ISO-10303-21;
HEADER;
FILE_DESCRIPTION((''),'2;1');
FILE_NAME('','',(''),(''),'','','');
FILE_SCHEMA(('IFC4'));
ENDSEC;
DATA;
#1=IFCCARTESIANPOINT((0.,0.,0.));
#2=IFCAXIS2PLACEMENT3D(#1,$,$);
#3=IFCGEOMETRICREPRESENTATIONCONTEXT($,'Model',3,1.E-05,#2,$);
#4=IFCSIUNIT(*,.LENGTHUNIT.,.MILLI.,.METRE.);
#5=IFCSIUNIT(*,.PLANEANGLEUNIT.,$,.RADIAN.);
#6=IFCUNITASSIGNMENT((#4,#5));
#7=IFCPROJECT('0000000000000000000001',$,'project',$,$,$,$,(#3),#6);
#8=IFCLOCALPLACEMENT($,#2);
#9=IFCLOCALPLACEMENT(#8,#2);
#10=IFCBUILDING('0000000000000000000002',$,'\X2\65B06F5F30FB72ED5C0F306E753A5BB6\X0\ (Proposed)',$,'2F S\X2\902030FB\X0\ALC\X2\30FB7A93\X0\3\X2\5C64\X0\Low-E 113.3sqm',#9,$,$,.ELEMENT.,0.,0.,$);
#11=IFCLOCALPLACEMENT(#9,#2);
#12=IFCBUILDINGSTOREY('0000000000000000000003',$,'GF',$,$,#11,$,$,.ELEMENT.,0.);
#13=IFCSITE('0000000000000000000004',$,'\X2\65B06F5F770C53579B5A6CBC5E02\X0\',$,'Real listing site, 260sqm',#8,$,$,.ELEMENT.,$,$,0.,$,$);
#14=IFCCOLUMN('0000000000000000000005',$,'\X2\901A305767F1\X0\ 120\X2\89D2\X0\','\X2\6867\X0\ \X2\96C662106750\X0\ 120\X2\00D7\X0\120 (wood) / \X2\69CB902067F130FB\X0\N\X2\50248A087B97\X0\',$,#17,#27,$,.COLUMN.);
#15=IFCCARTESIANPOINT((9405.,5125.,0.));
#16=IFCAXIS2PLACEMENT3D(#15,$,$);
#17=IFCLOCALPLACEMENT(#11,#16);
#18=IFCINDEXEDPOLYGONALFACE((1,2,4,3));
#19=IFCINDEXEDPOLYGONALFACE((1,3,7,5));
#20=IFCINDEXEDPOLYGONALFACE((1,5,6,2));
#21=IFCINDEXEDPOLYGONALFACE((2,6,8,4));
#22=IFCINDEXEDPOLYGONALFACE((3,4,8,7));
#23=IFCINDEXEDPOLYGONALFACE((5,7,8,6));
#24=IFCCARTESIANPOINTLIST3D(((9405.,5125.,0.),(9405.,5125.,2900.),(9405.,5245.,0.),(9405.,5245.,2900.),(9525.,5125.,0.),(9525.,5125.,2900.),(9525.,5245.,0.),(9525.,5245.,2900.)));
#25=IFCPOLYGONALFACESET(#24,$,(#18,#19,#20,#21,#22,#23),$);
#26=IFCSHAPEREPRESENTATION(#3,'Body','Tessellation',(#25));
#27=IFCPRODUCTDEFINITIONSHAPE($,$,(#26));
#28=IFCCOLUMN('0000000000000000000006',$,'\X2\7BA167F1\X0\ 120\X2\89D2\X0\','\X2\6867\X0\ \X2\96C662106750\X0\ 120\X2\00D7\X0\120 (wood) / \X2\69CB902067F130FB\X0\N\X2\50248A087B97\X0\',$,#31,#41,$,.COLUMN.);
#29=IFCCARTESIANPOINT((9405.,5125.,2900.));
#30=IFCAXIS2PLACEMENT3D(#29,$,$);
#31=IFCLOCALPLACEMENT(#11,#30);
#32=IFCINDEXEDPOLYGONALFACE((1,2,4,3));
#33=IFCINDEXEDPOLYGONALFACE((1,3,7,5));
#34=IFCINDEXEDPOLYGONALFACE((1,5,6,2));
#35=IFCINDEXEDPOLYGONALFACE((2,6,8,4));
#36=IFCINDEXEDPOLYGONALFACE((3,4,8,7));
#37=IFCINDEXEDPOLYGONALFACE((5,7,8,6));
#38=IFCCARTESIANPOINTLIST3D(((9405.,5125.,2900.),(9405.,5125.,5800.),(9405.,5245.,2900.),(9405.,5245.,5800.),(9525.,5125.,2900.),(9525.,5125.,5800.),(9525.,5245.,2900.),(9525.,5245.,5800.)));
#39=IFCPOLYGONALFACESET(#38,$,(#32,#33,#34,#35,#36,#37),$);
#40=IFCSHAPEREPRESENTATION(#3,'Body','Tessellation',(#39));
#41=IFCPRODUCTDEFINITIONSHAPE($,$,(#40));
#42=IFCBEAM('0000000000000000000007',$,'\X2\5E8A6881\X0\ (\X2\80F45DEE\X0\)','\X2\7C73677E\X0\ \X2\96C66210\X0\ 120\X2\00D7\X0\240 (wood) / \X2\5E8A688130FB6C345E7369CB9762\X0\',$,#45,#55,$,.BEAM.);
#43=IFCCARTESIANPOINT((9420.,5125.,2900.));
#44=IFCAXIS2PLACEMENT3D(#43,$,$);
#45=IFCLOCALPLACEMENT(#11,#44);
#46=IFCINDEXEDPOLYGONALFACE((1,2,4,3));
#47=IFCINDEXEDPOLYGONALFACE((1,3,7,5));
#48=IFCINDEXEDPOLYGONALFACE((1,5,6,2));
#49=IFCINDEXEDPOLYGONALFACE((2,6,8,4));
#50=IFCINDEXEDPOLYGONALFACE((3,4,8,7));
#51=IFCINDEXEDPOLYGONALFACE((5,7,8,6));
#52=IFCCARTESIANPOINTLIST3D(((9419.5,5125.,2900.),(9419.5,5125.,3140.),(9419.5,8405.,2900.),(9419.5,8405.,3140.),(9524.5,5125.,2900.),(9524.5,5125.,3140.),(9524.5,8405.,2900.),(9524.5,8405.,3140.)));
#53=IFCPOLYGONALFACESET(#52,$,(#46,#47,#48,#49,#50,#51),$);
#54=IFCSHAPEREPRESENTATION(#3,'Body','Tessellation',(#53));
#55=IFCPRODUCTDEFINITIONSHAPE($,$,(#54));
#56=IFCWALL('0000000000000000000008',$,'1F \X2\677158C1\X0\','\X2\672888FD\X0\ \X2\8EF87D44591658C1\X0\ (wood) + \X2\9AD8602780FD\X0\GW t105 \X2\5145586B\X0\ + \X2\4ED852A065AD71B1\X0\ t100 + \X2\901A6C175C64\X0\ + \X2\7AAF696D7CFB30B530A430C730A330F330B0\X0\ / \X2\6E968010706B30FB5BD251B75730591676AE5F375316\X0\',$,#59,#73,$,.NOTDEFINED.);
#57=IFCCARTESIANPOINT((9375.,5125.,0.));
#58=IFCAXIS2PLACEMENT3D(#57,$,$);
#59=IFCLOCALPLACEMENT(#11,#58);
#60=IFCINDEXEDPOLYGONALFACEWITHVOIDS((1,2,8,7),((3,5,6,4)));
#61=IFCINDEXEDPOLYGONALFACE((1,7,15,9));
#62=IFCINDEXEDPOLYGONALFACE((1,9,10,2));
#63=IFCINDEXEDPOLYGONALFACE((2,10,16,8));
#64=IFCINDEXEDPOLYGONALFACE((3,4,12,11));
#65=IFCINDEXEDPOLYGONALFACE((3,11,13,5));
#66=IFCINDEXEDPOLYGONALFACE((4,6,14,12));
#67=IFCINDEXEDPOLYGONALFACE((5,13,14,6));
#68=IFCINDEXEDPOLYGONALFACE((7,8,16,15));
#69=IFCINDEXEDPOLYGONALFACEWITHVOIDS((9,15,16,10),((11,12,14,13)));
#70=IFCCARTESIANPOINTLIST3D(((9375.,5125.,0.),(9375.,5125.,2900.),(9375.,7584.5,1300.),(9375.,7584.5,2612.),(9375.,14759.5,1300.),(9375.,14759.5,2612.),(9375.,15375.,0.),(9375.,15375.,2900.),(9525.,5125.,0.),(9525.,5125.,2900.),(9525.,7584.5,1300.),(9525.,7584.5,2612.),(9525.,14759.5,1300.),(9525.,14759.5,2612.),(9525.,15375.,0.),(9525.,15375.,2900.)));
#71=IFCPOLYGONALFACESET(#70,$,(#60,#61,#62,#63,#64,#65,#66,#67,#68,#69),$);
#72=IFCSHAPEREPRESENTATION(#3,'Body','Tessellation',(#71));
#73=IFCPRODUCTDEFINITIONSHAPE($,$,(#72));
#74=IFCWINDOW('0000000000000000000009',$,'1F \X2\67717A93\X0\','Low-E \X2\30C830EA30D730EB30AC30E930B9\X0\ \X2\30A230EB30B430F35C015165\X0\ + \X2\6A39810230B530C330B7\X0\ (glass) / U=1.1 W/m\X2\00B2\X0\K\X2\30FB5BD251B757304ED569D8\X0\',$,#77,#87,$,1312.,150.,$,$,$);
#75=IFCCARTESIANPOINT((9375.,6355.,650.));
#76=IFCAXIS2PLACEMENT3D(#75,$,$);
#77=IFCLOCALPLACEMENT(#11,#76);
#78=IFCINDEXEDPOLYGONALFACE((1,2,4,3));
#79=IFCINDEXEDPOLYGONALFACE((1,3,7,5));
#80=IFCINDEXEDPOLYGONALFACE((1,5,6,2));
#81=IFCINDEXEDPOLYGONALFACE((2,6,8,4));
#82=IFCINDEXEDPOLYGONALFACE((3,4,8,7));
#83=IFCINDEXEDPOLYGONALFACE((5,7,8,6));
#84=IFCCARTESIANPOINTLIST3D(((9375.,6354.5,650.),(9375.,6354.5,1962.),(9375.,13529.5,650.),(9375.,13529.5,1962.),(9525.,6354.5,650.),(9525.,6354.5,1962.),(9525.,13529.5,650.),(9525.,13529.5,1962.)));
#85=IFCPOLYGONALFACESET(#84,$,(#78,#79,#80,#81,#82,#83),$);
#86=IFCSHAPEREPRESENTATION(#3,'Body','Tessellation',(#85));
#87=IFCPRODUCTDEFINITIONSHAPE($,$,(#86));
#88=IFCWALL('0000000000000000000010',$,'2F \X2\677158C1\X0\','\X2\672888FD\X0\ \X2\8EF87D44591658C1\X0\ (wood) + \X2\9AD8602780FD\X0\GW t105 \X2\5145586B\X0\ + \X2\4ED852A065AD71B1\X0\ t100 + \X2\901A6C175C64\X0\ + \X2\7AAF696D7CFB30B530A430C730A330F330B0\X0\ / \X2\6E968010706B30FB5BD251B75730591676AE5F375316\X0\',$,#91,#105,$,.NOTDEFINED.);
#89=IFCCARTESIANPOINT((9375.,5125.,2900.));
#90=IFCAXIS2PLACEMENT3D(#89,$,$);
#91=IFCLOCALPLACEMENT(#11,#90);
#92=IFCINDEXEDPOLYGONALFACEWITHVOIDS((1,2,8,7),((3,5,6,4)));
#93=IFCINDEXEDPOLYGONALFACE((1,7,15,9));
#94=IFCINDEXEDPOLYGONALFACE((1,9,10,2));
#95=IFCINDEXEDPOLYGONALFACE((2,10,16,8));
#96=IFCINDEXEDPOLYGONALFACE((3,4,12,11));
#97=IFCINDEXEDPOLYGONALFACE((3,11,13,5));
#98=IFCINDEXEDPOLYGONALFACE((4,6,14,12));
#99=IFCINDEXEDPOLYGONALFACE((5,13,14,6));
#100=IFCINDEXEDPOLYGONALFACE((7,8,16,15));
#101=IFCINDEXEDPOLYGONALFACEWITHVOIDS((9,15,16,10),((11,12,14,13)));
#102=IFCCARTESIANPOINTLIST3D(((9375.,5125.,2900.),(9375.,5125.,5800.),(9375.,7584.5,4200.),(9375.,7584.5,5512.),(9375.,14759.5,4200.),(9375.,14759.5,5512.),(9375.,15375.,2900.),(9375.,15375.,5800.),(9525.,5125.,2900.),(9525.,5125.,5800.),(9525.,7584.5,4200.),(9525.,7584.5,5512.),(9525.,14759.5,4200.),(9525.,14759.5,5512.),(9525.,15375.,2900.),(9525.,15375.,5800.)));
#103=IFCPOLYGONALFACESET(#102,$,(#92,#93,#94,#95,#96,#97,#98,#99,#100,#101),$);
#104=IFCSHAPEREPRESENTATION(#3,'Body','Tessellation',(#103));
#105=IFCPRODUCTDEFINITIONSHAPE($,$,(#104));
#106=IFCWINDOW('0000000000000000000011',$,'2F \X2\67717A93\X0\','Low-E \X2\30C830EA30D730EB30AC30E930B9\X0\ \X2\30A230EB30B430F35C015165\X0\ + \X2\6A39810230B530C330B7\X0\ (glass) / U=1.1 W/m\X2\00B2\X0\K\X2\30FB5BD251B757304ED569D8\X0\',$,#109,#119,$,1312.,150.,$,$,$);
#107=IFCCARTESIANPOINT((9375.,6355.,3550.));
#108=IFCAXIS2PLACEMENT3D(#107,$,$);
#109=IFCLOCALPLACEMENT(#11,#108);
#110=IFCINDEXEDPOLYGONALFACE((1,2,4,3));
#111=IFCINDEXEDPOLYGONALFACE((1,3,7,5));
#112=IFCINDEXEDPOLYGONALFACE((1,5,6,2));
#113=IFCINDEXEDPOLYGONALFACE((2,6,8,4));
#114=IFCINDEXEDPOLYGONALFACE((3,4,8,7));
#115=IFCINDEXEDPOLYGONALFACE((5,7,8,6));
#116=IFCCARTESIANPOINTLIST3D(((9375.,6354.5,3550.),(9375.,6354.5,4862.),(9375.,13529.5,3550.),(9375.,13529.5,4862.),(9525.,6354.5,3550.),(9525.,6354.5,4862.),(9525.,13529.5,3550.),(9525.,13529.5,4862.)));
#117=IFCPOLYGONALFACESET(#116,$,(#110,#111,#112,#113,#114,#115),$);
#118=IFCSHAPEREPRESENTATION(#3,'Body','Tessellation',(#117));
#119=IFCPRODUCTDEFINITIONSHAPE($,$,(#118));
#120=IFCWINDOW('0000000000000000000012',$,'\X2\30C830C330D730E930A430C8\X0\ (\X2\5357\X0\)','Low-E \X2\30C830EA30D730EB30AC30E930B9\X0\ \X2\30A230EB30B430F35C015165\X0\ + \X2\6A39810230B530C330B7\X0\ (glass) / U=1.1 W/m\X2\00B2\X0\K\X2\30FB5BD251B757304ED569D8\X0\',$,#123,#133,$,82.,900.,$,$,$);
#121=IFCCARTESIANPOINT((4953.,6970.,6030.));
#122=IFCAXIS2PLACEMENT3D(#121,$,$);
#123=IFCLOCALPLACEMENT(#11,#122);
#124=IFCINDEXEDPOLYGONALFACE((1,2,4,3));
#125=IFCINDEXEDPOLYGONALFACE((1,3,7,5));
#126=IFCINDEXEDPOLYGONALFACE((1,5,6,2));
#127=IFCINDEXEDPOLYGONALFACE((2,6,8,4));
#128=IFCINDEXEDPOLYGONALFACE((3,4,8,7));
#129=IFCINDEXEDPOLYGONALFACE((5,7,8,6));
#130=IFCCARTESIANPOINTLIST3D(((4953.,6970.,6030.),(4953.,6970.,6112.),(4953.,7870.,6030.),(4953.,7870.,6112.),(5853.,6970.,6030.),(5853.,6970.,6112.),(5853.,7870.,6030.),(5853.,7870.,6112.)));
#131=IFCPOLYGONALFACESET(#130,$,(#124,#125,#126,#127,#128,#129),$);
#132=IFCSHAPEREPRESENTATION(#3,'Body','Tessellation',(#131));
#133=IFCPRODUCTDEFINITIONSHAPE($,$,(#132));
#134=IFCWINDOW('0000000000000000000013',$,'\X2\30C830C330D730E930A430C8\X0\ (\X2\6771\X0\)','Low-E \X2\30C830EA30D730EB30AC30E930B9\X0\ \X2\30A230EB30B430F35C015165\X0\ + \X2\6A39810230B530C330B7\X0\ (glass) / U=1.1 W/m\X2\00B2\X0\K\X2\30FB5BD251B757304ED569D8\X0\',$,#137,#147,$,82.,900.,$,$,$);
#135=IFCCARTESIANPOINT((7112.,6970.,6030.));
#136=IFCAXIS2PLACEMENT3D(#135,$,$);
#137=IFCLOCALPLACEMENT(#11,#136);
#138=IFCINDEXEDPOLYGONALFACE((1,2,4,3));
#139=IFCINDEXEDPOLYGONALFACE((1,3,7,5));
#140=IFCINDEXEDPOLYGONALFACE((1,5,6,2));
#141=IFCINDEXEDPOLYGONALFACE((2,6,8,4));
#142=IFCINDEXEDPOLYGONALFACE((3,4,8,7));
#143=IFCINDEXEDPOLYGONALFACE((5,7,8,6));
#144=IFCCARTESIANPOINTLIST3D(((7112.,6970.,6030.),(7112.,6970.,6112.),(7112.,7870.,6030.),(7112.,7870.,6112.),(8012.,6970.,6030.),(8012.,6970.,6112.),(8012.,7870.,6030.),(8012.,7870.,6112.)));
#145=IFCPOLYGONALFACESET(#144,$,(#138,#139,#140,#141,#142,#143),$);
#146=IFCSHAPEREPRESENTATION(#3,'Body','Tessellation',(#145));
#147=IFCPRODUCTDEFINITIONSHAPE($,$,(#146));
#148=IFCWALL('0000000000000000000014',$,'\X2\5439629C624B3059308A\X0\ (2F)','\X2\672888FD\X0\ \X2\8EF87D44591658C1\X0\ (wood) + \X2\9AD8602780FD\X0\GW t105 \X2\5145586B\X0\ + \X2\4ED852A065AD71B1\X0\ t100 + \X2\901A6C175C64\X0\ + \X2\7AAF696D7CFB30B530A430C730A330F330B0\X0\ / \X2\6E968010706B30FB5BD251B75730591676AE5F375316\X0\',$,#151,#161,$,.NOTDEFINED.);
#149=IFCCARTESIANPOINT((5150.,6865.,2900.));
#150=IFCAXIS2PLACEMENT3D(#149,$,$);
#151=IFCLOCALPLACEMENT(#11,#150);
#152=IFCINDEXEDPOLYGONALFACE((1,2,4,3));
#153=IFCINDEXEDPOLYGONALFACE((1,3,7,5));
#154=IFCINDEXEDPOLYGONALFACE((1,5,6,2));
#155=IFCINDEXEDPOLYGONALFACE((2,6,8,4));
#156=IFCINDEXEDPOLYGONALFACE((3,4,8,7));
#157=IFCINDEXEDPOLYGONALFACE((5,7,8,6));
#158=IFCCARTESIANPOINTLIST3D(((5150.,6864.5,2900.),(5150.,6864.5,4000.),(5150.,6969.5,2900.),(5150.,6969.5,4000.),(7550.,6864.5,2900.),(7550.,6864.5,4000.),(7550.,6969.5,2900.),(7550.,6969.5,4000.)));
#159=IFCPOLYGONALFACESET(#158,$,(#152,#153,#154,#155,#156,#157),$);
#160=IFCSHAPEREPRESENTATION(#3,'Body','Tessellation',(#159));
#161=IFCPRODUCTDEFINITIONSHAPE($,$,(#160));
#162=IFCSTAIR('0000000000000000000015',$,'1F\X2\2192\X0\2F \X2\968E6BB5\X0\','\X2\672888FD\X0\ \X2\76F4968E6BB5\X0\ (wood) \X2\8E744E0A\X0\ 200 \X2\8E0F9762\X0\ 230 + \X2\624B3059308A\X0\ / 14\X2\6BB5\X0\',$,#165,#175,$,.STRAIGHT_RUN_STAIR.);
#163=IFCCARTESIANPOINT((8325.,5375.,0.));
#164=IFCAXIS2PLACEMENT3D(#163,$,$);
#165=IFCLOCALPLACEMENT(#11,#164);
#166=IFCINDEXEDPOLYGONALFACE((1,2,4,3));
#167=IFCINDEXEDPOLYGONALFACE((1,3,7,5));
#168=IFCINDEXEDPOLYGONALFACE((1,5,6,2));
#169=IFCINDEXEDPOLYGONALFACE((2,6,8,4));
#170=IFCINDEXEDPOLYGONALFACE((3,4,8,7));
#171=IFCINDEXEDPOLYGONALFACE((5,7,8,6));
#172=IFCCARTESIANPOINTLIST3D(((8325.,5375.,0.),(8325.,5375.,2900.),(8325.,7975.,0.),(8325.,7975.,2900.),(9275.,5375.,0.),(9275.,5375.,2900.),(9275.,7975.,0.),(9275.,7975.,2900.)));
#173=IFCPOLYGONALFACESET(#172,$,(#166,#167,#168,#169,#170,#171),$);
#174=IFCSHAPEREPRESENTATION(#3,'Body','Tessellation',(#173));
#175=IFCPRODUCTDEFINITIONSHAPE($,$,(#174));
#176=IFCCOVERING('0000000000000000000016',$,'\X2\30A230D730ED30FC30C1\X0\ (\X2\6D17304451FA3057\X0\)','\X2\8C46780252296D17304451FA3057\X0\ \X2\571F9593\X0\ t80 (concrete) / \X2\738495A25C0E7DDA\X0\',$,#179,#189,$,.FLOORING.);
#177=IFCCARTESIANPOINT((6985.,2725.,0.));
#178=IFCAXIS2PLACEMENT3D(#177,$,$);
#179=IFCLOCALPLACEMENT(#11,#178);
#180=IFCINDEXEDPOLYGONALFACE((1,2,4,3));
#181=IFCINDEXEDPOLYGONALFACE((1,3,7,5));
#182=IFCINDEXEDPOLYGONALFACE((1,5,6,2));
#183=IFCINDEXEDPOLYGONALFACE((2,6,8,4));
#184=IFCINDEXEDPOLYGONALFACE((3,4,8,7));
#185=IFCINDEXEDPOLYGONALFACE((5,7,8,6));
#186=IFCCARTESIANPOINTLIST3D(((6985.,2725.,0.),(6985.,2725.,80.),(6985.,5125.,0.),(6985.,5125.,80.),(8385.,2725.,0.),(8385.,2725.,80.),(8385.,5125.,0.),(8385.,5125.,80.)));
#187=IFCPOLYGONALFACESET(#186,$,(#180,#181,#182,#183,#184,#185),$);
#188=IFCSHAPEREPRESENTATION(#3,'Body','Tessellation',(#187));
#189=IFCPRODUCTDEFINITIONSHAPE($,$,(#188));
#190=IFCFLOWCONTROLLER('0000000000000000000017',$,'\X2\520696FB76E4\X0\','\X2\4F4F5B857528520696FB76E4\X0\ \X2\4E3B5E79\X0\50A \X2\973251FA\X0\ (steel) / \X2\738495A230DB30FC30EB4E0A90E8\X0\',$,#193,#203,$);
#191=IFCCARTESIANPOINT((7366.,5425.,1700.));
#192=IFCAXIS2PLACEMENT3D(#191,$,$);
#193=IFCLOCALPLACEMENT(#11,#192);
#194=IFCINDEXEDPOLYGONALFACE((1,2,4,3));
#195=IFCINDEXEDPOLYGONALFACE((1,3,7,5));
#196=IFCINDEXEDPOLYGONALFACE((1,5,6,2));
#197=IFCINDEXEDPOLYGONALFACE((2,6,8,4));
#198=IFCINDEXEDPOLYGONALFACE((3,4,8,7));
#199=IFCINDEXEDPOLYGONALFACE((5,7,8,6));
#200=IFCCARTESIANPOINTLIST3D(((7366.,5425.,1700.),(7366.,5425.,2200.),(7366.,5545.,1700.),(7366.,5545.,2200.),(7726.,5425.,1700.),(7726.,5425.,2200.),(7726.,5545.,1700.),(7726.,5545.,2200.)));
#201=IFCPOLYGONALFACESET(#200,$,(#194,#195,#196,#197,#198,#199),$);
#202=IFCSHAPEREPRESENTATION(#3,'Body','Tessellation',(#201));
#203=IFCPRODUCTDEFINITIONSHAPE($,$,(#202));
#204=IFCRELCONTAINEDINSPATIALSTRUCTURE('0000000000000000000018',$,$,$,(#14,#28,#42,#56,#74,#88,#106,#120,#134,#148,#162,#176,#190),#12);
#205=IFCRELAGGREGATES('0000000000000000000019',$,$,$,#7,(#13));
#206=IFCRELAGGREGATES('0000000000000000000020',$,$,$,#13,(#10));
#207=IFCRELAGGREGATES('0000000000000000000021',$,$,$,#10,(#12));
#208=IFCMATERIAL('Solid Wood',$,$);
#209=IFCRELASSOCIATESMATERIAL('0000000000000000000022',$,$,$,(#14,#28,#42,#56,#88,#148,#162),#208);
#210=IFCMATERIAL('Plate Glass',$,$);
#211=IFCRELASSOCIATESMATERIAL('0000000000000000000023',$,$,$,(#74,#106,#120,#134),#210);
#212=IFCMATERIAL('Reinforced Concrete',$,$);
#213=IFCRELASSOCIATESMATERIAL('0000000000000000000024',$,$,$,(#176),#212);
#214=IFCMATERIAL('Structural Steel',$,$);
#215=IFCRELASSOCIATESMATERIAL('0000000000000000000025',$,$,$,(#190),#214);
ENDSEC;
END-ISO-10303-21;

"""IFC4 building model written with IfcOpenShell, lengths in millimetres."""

from ifc_helpers import new_model, si_unit, frame, frame_2d, origin, place, context, project, spatial, rectangle, extrude, material, element, fill, save


model = new_model("IFC4")

# Units and contexts
model_context = context("Model", 3, precision=1e-05, world=origin())
ifc_project = project(units=[si_unit("LENGTHUNIT", "METRE", prefix="MILLI"), si_unit("PLANEANGLEUNIT", "RADIAN")], contexts=[model_context])

# Site, building, storey
site_placement = place(None, origin())
site = spatial("IfcSite", under=ifc_project, at=site_placement, Name="新潟県南魚沼市", ObjectType="Real listing site, 260sqm", CompositionType="ELEMENT", RefElevation=0.0)
building_placement = place(site_placement, origin())
building = spatial("IfcBuilding", under=site, at=building_placement, Name="新潟・狭小の町家 (Proposed)", ObjectType="2F S造・ALC・窓3層Low-E 113.3sqm", CompositionType="ELEMENT", ElevationOfRefHeight=0.0, ElevationOfTerrain=0.0)
storey_placement = place(building_placement, origin())
storey = spatial("IfcBuildingStorey", under=building, at=storey_placement, Name="GF", CompositionType="ELEMENT", Elevation=0.0)

# Columns
ifc_material_1 = material(Name="Solid Wood")
column_1_placement = place(storey_placement, frame((9405.0, 5125.0, 0.0)))
element("IfcColumn", 1, at=column_1_placement, inside=storey, material=ifc_material_1, Name="通し柱 120角", Description="桧 集成材 120×120 (wood) / 構造柱・N値計算", PredefinedType="COLUMN", context=model_context, shape_type="SweptSolid", body=[
    extrude(rectangle(XDim=120.0, YDim=120.0, at=frame_2d((60.0, 60.0))), frame((9405.0, 5125.0, 0.0)), (0.0, 0.0, 1.0), 2900.0),
])
column_2_placement = place(storey_placement, frame((9405.0, 5125.0, 2900.0)))
element("IfcColumn", 2, at=column_2_placement, inside=storey, material=ifc_material_1, Name="管柱 120角", Description="桧 集成材 120×120 (wood) / 構造柱・N値計算", PredefinedType="COLUMN", context=model_context, shape_type="SweptSolid", body=[
    extrude(rectangle(XDim=120.0, YDim=120.0, at=frame_2d((60.0, 60.0))), frame((9405.0, 5125.0, 2900.0)), (0.0, 0.0, 1.0), 2900.0),
])

# Beam
beam_1_placement = place(storey_placement, frame((9420.0, 5125.0, 2900.0)))
element("IfcBeam", 3, at=beam_1_placement, inside=storey, material=ifc_material_1, Name="床梁 (胴差)", Description="米松 集成 120×240 (wood) / 床梁・水平構面", PredefinedType="BEAM", context=model_context, shape_type="SweptSolid", body=[
    extrude(rectangle(XDim=105.0, YDim=3280.0, at=frame_2d((52.0, 1640.0))), frame((9420.0, 5125.0, 2900.0)), (0.0, 0.0, 1.0), 240.0),
])

# Wall, opening, window
wall_1_placement = place(storey_placement, frame((9375.0, 5125.0, 0.0)))
wall_1 = element("IfcWall", 4, at=wall_1_placement, inside=storey, material=ifc_material_1, Name="1F 東壁", Description="木製 軸組外壁 (wood) + 高性能GW t105 充填 + 付加断熱 t100 + 通気層 + 窯業系サイディング / 準耐火・寒冷地外皮強化", PredefinedType="NOTDEFINED", context=model_context, shape_type="SweptSolid", body=[
    extrude(rectangle(XDim=150.0, YDim=10250.0, at=frame_2d((75.0, 5125.0))), frame((9375.0, 5125.0, 0.0)), (0.0, 0.0, 1.0), 2900.0),
])
opening_1_placement = place(storey_placement, frame((9375.0, 6355.0, 650.0)))
opening_1 = element("IfcOpeningElement", 5, at=opening_1_placement, cuts=wall_1, PredefinedType="NOTDEFINED", context=model_context, shape_type="SweptSolid", body=[
    extrude(rectangle(XDim=150.0, YDim=7175.0, at=frame_2d((75.0, 3587.0))), frame((9375.0, 6355.0, 650.0)), (0.0, 0.0, 1.0), 1312.0),
])
ifc_material_2 = material(Name="Plate Glass")
window_1_placement = place(storey_placement, frame((9375.0, 6355.0, 650.0)))
window_1 = element("IfcWindow", 6, at=window_1_placement, inside=storey, material=ifc_material_2, Name="1F 東窓", Description="Low-E トリプルガラス アルゴン封入 + 樹脂サッシ (glass) / U=1.1 W/m²K・寒冷地仕様", OverallHeight=1312.0, OverallWidth=150.0, context=model_context, shape_type="SweptSolid", body=[
    extrude(rectangle(XDim=150.0, YDim=7175.0, at=frame_2d((75.0, 3587.0))), frame((9375.0, 6355.0, 650.0)), (0.0, 0.0, 1.0), 1312.0),
])
fill(opening_1, window_1)

# Wall, opening, window
wall_2_placement = place(storey_placement, frame((9375.0, 5125.0, 2900.0)))
wall_2 = element("IfcWall", 7, at=wall_2_placement, inside=storey, material=ifc_material_1, Name="2F 東壁", Description="木製 軸組外壁 (wood) + 高性能GW t105 充填 + 付加断熱 t100 + 通気層 + 窯業系サイディング / 準耐火・寒冷地外皮強化", PredefinedType="NOTDEFINED", context=model_context, shape_type="SweptSolid", body=[
    extrude(rectangle(XDim=150.0, YDim=10250.0, at=frame_2d((75.0, 5125.0))), frame((9375.0, 5125.0, 2900.0)), (0.0, 0.0, 1.0), 2900.0),
])
opening_2_placement = place(storey_placement, frame((9375.0, 6355.0, 3550.0)))
opening_2 = element("IfcOpeningElement", 8, at=opening_2_placement, cuts=wall_2, PredefinedType="NOTDEFINED", context=model_context, shape_type="SweptSolid", body=[
    extrude(rectangle(XDim=150.0, YDim=7175.0, at=frame_2d((75.0, 3587.0))), frame((9375.0, 6355.0, 3550.0)), (0.0, 0.0, 1.0), 1312.0),
])
window_2_placement = place(storey_placement, frame((9375.0, 6355.0, 3550.0)))
window_2 = element("IfcWindow", 9, at=window_2_placement, inside=storey, material=ifc_material_2, Name="2F 東窓", Description="Low-E トリプルガラス アルゴン封入 + 樹脂サッシ (glass) / U=1.1 W/m²K・寒冷地仕様", OverallHeight=1312.0, OverallWidth=150.0, context=model_context, shape_type="SweptSolid", body=[
    extrude(rectangle(XDim=150.0, YDim=7175.0, at=frame_2d((75.0, 3587.0))), frame((9375.0, 6355.0, 3550.0)), (0.0, 0.0, 1.0), 1312.0),
])
fill(opening_2, window_2)

# Windows
window_3_placement = place(storey_placement, frame((4953.0, 6970.0, 6030.0)))
element("IfcWindow", 10, at=window_3_placement, inside=storey, material=ifc_material_2, Name="トップライト (南)", Description="Low-E トリプルガラス アルゴン封入 + 樹脂サッシ (glass) / U=1.1 W/m²K・寒冷地仕様", OverallHeight=82.0, OverallWidth=900.0, context=model_context, shape_type="SweptSolid", body=[
    extrude(rectangle(XDim=900.0, YDim=900.0, at=frame_2d((450.0, 450.0))), frame((4953.0, 6970.0, 6030.0)), (0.0, 0.0, 1.0), 82.0),
])
window_4_placement = place(storey_placement, frame((7112.0, 6970.0, 6030.0)))
element("IfcWindow", 11, at=window_4_placement, inside=storey, material=ifc_material_2, Name="トップライト (東)", Description="Low-E トリプルガラス アルゴン封入 + 樹脂サッシ (glass) / U=1.1 W/m²K・寒冷地仕様", OverallHeight=82.0, OverallWidth=900.0, context=model_context, shape_type="SweptSolid", body=[
    extrude(rectangle(XDim=900.0, YDim=900.0, at=frame_2d((450.0, 450.0))), frame((7112.0, 6970.0, 6030.0)), (0.0, 0.0, 1.0), 82.0),
])

# Wall
wall_3_placement = place(storey_placement, frame((5150.0, 6865.0, 2900.0)))
element("IfcWall", 12, at=wall_3_placement, inside=storey, material=ifc_material_1, Name="吹抜手すり (2F)", Description="木製 軸組外壁 (wood) + 高性能GW t105 充填 + 付加断熱 t100 + 通気層 + 窯業系サイディング / 準耐火・寒冷地外皮強化", PredefinedType="NOTDEFINED", context=model_context, shape_type="SweptSolid", body=[
    extrude(rectangle(XDim=2400.0, YDim=105.0, at=frame_2d((1200.0, 52.0))), frame((5150.0, 6865.0, 2900.0)), (0.0, 0.0, 1.0), 1100.0),
])

# Stair
stair_placement = place(storey_placement, frame((8325.0, 5375.0, 0.0)))
element("IfcStair", 13, at=stair_placement, inside=storey, material=ifc_material_1, Name="1F→2F 階段", Description="木製 直階段 (wood) 蹴上 200 踏面 230 + 手すり / 14段", PredefinedType="STRAIGHT_RUN_STAIR", context=model_context, shape_type="SweptSolid", body=[
    extrude(rectangle(XDim=950.0, YDim=2600.0, at=frame_2d((475.0, 1300.0))), frame((8325.0, 5375.0, 0.0)), (0.0, 0.0, 1.0), 2900.0),
])

# Covering
ifc_material_3 = material(Name="Reinforced Concrete")
covering_placement = place(storey_placement, frame((6985.0, 2725.0, 0.0)))
element("IfcCovering", 14, at=covering_placement, inside=storey, material=ifc_material_3, Name="アプローチ (洗い出し)", Description="豆砂利洗い出し 土間 t80 (concrete) / 玄関導線", PredefinedType="FLOORING", context=model_context, shape_type="SweptSolid", body=[
    extrude(rectangle(XDim=1400.0, YDim=2400.0, at=frame_2d((700.0, 1200.0))), frame((6985.0, 2725.0, 0.0)), (0.0, 0.0, 1.0), 80.0),
])

# Flow controller
ifc_material_4 = material(Name="Structural Steel")
flow_controller_placement = place(storey_placement, frame((7366.0, 5425.0, 1700.0)))
element("IfcFlowController", 15, at=flow_controller_placement, inside=storey, material=ifc_material_4, Name="分電盤", Description="住宅用分電盤 主幹50A 露出 (steel) / 玄関ホール上部", context=model_context, shape_type="SweptSolid", body=[
    extrude(rectangle(XDim=360.0, YDim=120.0, at=frame_2d((180.0, 60.0))), frame((7366.0, 5425.0, 1700.0)), (0.0, 0.0, 1.0), 500.0),
])

save(model, "model.ifc")
